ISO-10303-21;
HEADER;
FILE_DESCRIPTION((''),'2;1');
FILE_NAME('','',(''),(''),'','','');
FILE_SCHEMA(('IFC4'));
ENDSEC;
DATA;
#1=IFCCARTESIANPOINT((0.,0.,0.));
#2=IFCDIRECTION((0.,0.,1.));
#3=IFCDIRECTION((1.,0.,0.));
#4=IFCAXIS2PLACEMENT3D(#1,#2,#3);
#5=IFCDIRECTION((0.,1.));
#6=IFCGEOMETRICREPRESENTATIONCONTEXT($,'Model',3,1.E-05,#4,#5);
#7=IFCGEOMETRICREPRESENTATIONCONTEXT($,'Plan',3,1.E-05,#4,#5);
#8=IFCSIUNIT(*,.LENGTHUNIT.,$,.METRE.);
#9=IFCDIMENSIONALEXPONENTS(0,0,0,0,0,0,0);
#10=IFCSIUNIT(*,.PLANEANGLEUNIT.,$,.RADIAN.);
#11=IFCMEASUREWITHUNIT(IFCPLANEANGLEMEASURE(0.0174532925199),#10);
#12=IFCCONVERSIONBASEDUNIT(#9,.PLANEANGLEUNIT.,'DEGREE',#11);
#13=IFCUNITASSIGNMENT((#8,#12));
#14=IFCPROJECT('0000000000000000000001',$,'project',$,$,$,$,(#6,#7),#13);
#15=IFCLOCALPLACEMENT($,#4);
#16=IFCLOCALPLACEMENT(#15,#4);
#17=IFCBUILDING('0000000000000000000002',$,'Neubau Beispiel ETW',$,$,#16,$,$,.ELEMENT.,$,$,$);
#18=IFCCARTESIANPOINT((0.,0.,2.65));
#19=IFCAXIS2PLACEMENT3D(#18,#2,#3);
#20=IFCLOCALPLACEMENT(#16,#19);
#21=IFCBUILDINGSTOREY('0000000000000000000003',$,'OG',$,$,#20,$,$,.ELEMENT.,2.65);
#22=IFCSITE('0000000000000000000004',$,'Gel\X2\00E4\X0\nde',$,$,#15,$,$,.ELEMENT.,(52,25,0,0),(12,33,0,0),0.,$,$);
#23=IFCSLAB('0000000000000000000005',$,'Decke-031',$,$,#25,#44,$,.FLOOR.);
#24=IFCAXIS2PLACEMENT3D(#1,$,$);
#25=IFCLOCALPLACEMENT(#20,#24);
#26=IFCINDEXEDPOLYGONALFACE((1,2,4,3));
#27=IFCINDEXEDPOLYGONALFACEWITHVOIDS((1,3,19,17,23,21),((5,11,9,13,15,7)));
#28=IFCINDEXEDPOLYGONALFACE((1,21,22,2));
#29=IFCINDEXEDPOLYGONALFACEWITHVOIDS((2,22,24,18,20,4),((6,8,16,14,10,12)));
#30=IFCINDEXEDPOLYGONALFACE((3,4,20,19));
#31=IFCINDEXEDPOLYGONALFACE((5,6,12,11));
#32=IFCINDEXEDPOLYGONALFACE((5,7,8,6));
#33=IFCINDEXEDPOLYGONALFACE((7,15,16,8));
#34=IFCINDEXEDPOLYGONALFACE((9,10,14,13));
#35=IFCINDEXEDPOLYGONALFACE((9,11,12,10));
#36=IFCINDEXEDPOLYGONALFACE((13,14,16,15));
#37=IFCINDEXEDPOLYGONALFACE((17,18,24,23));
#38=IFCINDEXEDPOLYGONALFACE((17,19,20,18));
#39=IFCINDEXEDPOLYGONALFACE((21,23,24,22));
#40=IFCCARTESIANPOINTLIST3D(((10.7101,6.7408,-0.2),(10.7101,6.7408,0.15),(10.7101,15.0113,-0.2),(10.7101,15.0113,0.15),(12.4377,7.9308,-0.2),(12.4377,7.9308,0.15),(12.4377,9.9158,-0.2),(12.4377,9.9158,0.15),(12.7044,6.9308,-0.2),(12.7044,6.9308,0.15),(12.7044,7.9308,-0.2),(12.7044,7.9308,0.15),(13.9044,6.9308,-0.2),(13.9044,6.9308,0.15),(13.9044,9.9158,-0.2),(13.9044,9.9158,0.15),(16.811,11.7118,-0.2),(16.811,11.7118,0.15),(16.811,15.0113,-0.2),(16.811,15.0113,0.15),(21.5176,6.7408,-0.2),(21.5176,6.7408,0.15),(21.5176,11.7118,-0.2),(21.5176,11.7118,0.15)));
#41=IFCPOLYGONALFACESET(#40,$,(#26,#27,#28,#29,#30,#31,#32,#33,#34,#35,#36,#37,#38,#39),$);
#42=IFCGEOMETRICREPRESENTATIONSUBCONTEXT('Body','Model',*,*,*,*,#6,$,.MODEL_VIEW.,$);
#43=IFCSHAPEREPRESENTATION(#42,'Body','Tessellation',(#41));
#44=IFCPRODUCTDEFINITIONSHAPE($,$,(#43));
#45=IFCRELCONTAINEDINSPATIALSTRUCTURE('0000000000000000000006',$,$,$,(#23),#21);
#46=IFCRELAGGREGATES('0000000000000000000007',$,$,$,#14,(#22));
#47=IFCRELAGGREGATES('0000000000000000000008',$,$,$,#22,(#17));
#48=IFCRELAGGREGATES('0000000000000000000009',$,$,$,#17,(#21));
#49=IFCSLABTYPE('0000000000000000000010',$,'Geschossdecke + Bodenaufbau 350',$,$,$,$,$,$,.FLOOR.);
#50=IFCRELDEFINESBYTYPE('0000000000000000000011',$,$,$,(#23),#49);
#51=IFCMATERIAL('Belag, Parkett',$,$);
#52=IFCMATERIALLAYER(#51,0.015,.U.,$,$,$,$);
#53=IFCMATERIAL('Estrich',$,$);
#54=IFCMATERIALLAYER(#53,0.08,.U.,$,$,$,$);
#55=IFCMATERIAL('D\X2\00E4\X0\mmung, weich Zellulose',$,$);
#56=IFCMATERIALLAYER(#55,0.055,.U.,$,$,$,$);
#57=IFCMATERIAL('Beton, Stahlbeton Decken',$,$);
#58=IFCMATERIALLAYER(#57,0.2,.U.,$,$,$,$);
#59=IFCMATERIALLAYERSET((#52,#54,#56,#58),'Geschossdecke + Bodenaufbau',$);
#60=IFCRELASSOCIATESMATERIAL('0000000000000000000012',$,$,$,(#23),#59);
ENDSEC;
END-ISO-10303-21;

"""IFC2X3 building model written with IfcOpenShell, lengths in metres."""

from ifc_helpers import new_model, entity, si_unit, converted_unit, direction, frame, origin_with_axes, place, context, subcontext, project, spatial, polyline, outline, extrude, material, layer, layer_set, layer_usage, type_object, element, save


model = new_model("IFC2X3")

# Units and contexts
model_context = context("Model", 3, precision=1e-05, world=origin_with_axes(), true_north=direction((0.0, 1.0)))
plan_context = context("Plan", 3, precision=1e-05, world=origin_with_axes(), true_north=direction((0.0, 1.0)))
body_context = subcontext(model_context, "Body", "Model", "MODEL_VIEW")
ifc_project = project(units=[si_unit("LENGTHUNIT", "METRE"), converted_unit("PLANEANGLEUNIT", "DEGREE", entity("IfcPlaneAngleMeasure", 0.0174532925199), si_unit("PLANEANGLEUNIT", "RADIAN"), dimensions=[0, 0, 0, 0, 0, 0, 0])], contexts=[model_context, plan_context])

# Site, building, storey
site_placement = place(None, origin_with_axes())
site = spatial("IfcSite", under=ifc_project, at=site_placement, Name="Gelände", CompositionType="ELEMENT", RefLatitude=(52, 25, 0, 0), RefLongitude=(12, 33, 0, 0), RefElevation=0.0)
building_placement = place(site_placement, origin_with_axes())
building = spatial("IfcBuilding", under=site, at=building_placement, Name="Neubau Beispiel ETW", CompositionType="ELEMENT")
storey_placement = place(building_placement, frame((0.0, 0.0, 2.65), z_axis=(0.0, 0.0, 1.0), x_axis=(1.0, 0.0, 0.0)))
storey = spatial("IfcBuildingStorey", under=building, at=storey_placement, Name="OG", CompositionType="ELEMENT", Elevation=2.65)

# Slab, opening
ifc_material_1 = material(Name="Belag, Parkett")
ifc_layer_1 = layer(ifc_material_1, 0.015, ventilated="UNKNOWN")
ifc_material_2 = material(Name="Estrich")
ifc_layer_2 = layer(ifc_material_2, 0.08, ventilated="UNKNOWN")
ifc_material_3 = material(Name="Dämmung, weich Zellulose")
ifc_layer_3 = layer(ifc_material_3, 0.055, ventilated="UNKNOWN")
ifc_material_4 = material(Name="Beton, Stahlbeton Decken")
ifc_layer_4 = layer(ifc_material_4, 0.2, ventilated="UNKNOWN")
ifc_layer_set = layer_set([ifc_layer_1, ifc_layer_2, ifc_layer_3, ifc_layer_4], Name="Geschossdecke + Bodenaufbau")
ifc_layer_usage = layer_usage(ifc_layer_set, "AXIS3", "NEGATIVE", 0.35)
slab_type = type_object("IfcSlabType", Name="Geschossdecke + Bodenaufbau 350", PredefinedType="FLOOR")
slab_placement = place(storey_placement, frame((10.7101, 15.0113, 0.15), z_axis=(0.0, 0.0, 1.0), x_axis=(1.0, 0.0, 0.0)))
slab = element("IfcSlab", 1, at=slab_placement, inside=storey, type_object=slab_type, material=ifc_layer_usage, Name="Decke-031", PredefinedType="FLOOR", context=body_context, shape_type="SweptSolid", body=[
    extrude(outline(polyline([(0.0, 0.0), (0.0, -8.2705), (10.8075, -8.2705), (10.8075, -3.2995), (6.101, -3.2995), (6.101, 0.0), (0.0, 0.0)])), frame((0.0, 0.0, -0.35), z_axis=(0.0, 0.0, 1.0), x_axis=(1.0, 0.0, 0.0)), (0.0, 0.0, 1.0), 0.35),
])
opening_placement = place(slab_placement, origin_with_axes())
element("IfcOpeningElement", 2, at=opening_placement, cuts=slab, context=body_context, shape_type="SweptSolid", body=[
    extrude(outline(polyline([(1.7276, -5.0955), (1.7276, -7.0805), (1.9943, -7.0805), (1.9943, -8.0805), (3.1943, -8.0805), (3.1943, -5.0955), (1.7276, -5.0955)])), frame((0.0, 0.0, -0.35), z_axis=(0.0, 0.0, 1.0), x_axis=(1.0, 0.0, 0.0)), (0.0, 0.0, 1.0), 0.35),
])

save(model, "model.ifc")
